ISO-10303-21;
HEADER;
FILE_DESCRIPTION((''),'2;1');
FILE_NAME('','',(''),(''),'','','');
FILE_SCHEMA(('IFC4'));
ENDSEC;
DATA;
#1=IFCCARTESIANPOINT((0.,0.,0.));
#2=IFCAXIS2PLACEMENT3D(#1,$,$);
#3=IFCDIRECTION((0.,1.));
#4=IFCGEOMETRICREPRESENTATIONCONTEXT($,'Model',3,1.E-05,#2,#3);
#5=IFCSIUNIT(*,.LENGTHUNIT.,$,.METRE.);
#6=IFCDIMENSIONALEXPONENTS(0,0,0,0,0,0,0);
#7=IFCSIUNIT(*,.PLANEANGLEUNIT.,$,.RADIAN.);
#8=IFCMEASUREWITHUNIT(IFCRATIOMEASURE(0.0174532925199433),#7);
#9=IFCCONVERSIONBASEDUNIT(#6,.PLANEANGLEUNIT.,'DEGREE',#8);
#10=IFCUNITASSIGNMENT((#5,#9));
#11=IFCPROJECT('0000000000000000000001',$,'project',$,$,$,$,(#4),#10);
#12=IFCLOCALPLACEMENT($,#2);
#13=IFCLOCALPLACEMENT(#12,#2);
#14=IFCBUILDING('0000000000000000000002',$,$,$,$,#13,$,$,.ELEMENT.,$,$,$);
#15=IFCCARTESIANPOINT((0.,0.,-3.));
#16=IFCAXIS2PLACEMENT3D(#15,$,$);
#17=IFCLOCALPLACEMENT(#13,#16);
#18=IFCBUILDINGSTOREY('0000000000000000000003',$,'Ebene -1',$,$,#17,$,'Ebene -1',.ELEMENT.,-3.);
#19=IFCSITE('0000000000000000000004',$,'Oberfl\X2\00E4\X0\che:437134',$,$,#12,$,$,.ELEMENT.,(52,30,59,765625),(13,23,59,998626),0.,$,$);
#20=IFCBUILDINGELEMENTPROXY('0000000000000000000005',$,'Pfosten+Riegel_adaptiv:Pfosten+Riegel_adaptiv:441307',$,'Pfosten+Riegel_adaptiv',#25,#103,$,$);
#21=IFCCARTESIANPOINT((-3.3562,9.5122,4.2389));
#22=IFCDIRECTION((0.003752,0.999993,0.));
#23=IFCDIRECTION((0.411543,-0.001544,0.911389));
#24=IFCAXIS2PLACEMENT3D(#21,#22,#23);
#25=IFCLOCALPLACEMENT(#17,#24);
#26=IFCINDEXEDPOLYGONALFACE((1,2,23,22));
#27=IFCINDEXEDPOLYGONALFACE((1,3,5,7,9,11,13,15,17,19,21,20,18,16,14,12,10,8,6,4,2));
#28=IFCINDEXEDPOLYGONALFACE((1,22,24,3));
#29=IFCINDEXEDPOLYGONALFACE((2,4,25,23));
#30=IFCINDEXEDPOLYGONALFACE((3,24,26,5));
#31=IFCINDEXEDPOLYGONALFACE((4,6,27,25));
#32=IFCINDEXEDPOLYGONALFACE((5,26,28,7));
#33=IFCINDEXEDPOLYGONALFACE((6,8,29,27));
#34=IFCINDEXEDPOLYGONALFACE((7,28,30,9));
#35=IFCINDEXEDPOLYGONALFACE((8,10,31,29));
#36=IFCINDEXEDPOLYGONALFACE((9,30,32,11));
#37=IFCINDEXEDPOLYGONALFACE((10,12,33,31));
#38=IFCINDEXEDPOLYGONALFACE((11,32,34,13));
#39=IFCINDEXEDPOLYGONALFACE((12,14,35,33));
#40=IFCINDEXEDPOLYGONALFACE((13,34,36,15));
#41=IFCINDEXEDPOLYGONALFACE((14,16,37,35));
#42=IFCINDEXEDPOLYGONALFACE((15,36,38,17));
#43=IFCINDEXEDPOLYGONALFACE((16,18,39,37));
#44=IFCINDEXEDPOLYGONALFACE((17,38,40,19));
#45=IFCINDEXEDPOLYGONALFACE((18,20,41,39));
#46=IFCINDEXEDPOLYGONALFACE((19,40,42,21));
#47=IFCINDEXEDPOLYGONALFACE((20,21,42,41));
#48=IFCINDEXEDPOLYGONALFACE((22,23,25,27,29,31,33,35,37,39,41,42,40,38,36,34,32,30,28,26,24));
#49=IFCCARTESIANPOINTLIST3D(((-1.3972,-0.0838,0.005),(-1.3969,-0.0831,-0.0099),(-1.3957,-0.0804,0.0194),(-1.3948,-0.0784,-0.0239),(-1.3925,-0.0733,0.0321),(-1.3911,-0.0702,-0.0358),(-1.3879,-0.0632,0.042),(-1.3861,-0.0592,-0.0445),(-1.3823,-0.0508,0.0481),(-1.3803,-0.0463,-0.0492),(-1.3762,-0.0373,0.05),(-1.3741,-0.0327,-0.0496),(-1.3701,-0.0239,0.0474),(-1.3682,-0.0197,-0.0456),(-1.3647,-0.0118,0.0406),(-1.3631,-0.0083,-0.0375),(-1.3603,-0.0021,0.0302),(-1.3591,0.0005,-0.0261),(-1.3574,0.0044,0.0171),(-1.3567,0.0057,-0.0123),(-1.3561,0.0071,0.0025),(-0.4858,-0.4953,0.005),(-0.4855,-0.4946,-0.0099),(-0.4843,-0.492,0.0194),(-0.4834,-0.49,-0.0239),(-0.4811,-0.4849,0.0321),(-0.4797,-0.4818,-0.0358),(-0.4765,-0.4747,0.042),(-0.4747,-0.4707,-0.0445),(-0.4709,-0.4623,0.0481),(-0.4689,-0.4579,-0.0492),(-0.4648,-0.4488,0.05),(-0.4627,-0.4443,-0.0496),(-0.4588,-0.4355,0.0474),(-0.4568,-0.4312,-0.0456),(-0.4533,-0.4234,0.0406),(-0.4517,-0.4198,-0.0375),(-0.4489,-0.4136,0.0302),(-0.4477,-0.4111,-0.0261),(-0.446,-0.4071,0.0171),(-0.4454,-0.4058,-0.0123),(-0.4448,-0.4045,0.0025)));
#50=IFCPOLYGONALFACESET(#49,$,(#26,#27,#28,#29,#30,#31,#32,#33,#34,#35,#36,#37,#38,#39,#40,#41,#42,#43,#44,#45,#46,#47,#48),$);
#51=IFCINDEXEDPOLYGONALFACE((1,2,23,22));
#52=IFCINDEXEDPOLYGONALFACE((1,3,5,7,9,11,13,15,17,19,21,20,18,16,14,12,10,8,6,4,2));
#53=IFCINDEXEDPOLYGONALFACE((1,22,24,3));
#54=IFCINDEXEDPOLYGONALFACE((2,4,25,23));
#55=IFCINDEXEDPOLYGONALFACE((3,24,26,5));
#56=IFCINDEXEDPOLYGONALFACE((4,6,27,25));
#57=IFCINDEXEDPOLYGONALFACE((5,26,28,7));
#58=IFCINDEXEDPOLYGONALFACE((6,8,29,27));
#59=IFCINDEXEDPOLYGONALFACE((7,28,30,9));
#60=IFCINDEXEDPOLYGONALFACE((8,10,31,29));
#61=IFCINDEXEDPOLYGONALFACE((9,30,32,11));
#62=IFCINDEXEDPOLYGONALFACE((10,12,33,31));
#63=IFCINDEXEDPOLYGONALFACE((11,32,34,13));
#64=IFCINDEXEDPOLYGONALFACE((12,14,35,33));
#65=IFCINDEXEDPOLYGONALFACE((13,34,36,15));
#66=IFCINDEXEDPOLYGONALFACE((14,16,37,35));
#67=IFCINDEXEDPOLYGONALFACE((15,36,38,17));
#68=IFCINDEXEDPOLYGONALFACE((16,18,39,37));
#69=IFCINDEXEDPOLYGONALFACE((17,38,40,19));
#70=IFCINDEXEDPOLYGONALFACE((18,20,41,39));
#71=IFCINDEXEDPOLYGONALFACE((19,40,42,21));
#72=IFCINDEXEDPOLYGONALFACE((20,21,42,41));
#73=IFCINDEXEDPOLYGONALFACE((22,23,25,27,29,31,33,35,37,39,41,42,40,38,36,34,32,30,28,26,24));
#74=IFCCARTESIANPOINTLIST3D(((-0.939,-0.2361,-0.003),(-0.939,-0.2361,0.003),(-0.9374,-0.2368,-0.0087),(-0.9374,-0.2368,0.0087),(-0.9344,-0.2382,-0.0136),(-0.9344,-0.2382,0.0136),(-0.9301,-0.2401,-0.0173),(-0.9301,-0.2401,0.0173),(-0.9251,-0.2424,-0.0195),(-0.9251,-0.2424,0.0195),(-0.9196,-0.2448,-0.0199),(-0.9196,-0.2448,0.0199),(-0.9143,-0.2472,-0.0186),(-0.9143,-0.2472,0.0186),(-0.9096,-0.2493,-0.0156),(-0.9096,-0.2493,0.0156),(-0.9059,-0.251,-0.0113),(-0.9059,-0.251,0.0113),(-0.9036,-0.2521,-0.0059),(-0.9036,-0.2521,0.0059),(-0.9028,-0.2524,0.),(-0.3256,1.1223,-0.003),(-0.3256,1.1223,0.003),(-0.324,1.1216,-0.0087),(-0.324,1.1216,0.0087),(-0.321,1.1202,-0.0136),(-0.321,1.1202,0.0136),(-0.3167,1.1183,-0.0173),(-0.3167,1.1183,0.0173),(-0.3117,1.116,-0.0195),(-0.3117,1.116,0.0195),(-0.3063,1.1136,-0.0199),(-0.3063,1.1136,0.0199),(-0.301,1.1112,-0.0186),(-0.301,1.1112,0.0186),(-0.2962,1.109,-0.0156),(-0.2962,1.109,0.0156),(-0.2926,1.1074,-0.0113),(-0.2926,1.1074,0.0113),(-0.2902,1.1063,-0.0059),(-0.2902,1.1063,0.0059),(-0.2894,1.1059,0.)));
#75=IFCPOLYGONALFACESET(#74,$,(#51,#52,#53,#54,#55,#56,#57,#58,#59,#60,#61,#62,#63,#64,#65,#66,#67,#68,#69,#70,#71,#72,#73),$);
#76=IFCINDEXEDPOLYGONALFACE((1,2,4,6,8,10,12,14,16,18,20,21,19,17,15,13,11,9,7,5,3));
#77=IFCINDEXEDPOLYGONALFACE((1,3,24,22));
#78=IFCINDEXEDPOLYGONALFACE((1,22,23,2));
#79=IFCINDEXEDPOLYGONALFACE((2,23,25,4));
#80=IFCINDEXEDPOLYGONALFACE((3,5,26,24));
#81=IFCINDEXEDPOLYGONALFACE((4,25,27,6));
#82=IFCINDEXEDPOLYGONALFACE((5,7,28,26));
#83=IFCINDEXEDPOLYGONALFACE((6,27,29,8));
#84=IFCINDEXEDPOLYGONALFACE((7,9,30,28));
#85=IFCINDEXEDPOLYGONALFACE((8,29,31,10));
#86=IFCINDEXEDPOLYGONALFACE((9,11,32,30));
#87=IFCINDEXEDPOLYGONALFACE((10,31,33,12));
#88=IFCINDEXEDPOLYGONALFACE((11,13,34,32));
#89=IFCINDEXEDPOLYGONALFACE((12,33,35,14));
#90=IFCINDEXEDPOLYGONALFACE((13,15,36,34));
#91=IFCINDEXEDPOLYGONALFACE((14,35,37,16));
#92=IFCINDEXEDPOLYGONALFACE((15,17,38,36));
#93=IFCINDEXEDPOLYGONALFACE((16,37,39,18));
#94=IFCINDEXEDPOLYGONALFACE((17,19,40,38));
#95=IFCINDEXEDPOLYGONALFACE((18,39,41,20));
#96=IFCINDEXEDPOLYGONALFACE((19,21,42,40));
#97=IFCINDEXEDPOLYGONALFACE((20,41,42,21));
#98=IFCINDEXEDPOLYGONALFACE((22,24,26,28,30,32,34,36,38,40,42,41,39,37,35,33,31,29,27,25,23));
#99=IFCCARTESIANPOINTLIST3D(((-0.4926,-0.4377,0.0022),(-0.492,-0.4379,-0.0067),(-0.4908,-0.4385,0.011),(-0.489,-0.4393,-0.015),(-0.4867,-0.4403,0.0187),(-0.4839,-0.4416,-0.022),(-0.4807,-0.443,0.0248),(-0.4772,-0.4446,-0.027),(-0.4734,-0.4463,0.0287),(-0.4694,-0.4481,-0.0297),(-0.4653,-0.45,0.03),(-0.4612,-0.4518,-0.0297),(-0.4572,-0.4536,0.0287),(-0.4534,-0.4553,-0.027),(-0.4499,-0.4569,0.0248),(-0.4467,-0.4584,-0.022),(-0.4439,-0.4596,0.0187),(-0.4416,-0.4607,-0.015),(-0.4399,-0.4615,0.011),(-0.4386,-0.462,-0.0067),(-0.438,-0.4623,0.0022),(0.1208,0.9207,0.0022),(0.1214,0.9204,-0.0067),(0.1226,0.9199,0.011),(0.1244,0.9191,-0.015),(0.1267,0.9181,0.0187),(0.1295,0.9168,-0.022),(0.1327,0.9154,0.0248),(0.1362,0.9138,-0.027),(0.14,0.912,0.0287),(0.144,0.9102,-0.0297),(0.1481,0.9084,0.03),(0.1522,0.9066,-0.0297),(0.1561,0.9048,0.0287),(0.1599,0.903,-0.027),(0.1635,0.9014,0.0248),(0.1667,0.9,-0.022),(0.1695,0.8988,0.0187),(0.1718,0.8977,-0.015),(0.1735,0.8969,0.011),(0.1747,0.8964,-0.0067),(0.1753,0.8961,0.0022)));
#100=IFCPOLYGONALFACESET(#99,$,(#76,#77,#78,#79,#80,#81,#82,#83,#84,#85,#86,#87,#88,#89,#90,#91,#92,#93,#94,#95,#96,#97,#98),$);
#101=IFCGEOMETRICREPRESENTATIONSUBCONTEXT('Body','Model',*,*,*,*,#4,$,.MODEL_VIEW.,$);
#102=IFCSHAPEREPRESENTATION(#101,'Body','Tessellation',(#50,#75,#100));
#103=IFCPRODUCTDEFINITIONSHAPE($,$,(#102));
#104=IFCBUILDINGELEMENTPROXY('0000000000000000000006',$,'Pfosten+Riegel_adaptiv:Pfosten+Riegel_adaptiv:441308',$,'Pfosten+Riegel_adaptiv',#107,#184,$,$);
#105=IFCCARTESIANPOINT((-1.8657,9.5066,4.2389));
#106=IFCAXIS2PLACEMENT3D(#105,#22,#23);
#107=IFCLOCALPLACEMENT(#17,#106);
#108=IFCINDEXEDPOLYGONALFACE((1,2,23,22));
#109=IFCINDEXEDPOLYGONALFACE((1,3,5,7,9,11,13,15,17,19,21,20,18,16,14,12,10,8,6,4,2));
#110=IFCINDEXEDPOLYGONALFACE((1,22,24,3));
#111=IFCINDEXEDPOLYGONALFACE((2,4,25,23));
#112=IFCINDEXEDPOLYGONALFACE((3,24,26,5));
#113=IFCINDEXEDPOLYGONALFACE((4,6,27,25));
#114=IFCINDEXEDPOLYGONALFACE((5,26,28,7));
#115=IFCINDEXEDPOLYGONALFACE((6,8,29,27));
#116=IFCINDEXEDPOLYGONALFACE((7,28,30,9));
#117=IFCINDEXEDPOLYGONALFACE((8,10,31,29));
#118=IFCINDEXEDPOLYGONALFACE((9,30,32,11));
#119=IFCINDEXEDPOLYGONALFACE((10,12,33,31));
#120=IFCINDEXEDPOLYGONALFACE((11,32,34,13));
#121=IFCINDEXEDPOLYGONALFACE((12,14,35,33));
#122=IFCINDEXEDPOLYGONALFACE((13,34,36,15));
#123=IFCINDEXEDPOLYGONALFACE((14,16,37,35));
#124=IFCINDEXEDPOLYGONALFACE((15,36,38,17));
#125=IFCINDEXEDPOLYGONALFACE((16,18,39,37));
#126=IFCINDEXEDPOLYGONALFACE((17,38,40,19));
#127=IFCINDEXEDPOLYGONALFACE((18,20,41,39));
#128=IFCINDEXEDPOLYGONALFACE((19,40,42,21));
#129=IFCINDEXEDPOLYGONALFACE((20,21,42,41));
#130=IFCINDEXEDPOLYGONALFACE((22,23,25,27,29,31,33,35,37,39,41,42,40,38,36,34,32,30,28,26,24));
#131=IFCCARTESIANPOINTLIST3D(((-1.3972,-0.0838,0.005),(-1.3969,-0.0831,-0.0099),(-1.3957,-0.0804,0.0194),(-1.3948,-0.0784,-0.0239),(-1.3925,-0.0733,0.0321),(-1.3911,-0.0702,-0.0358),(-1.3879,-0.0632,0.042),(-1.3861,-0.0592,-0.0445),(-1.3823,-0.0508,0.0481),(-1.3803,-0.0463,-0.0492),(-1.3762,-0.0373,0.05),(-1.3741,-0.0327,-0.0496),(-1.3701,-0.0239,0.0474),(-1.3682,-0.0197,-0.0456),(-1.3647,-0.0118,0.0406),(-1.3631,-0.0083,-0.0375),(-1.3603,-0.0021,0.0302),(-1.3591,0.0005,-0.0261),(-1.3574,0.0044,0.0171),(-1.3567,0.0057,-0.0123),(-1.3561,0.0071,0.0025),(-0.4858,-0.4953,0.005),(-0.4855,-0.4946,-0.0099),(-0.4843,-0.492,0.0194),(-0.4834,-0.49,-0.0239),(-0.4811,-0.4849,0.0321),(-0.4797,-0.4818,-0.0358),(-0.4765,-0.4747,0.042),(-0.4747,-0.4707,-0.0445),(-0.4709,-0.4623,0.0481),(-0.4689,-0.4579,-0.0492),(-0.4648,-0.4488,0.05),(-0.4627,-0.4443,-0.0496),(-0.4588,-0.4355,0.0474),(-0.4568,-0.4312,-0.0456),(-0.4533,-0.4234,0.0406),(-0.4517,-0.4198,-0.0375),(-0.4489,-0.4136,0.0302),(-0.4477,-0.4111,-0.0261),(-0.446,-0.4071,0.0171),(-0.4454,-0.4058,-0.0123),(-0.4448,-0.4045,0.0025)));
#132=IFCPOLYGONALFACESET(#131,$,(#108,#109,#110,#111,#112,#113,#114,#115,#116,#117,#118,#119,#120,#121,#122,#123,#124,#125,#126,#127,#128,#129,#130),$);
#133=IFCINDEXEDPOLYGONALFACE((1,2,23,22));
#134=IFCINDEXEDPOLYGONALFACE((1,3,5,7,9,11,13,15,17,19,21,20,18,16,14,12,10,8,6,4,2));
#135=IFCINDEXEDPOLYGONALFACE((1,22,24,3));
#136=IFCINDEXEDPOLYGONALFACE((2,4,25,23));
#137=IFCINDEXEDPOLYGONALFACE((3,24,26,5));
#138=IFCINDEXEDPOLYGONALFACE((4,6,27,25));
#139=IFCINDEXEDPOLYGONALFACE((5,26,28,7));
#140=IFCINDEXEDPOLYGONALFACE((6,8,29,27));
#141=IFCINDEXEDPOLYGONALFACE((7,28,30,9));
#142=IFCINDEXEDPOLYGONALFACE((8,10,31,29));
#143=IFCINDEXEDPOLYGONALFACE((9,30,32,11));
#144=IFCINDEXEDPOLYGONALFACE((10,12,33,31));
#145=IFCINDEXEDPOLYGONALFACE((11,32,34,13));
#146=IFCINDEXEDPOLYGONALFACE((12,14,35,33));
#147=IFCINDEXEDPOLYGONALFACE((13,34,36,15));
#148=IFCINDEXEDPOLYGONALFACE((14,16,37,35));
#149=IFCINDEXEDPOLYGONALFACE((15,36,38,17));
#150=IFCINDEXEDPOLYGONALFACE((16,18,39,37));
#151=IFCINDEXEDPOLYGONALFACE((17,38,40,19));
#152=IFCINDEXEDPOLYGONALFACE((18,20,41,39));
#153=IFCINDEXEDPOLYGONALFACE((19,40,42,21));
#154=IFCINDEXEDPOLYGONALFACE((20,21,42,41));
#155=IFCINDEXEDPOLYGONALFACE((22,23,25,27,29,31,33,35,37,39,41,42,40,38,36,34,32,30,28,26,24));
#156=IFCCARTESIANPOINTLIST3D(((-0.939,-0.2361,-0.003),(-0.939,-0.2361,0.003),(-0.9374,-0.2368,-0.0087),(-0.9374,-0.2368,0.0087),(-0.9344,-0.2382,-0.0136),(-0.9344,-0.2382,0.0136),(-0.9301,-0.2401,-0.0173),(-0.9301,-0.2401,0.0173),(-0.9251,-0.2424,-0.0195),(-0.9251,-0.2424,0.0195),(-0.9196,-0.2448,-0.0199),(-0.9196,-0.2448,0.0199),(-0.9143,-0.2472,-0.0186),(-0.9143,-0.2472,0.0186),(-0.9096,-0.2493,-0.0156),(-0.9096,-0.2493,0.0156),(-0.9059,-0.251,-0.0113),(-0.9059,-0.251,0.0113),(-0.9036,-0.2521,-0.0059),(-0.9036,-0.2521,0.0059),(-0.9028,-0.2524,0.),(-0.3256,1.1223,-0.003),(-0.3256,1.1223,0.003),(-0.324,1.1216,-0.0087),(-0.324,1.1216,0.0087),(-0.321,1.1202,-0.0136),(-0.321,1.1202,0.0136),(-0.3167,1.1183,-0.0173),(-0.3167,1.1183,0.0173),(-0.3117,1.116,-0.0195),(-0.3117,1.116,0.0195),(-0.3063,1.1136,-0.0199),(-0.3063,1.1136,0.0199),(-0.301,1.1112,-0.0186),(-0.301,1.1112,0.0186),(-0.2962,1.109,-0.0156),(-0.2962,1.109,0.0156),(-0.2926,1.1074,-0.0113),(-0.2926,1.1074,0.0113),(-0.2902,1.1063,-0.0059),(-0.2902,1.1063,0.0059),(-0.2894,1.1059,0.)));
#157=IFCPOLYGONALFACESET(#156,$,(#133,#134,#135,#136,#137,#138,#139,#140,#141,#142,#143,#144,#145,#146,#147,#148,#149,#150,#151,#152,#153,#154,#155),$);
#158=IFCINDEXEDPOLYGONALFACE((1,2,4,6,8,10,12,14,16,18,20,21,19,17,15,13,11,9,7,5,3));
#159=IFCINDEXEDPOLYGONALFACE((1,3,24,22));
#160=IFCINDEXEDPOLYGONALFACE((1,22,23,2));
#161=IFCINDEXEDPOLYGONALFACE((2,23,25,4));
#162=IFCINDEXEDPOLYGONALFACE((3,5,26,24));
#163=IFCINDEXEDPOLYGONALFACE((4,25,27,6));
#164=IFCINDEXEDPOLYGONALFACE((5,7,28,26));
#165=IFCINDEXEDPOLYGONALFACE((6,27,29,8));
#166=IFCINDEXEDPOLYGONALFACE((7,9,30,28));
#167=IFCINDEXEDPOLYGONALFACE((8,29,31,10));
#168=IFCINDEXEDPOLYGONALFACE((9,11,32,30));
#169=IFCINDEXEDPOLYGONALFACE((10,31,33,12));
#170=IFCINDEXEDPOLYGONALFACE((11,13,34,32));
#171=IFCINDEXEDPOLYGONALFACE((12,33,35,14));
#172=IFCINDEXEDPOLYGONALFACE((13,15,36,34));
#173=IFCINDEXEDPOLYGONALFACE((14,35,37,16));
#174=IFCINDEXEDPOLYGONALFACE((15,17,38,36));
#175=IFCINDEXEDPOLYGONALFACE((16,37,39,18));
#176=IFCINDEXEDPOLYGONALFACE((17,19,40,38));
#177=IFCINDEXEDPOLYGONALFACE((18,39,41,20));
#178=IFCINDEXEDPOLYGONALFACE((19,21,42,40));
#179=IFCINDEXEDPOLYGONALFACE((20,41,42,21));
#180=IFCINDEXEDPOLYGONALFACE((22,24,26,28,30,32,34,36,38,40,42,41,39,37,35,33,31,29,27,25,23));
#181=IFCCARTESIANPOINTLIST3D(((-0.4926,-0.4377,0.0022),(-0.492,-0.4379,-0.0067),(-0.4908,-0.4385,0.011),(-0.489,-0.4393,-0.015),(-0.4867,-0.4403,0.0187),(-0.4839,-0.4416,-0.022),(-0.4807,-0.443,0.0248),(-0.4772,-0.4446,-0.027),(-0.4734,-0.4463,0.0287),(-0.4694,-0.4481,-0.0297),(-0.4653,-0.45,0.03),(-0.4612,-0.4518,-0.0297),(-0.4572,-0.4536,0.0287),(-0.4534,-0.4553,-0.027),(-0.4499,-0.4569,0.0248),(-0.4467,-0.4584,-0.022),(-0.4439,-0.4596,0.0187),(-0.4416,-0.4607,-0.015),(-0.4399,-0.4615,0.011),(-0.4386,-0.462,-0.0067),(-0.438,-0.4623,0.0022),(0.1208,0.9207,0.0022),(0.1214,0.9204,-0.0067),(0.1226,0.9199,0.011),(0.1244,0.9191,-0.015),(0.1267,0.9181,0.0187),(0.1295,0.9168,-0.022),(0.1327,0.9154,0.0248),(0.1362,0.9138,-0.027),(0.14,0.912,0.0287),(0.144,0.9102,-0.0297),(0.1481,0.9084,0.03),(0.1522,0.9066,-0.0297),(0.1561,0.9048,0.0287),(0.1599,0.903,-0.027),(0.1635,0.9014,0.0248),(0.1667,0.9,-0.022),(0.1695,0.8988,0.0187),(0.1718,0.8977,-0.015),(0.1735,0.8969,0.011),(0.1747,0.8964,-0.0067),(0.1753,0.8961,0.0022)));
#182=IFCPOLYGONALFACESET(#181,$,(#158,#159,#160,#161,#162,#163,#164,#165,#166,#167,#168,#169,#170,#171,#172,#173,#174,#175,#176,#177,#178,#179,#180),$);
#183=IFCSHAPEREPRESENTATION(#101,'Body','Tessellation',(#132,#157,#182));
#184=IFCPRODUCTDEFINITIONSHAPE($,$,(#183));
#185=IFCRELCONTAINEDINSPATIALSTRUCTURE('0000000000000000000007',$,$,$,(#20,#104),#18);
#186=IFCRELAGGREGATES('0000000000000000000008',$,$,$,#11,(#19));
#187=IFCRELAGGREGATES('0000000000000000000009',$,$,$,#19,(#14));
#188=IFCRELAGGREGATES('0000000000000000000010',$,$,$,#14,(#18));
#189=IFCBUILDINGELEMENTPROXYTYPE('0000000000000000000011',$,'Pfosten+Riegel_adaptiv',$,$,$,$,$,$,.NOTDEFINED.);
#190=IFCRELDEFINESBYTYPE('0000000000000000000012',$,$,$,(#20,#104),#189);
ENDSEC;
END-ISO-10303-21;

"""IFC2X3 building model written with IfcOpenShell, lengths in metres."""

from ifc_helpers import new_model, entity, si_unit, converted_unit, direction, frame, frame_2d, origin, place, context, subcontext, project, spatial, circle, extrude, source, transform, mapped, type_object, type_shapes, element, save


model = new_model("IFC2X3")

# Units and contexts
model_context = context("Model", 3, precision=1e-05, world=origin(), true_north=direction((0.0, 1.0)))
body_context = subcontext(model_context, "Body", "Model", "MODEL_VIEW")
ifc_project = project(units=[si_unit("LENGTHUNIT", "METRE"), converted_unit("PLANEANGLEUNIT", "DEGREE", entity("IfcRatioMeasure", 0.0174532925199433), si_unit("PLANEANGLEUNIT", "RADIAN"), dimensions=[0, 0, 0, 0, 0, 0, 0])], contexts=[model_context])

# Site, building, storey
site_placement = place(None, origin())
site = spatial("IfcSite", under=ifc_project, at=site_placement, Name="Oberfläche:437134", CompositionType="ELEMENT", RefLatitude=(52, 30, 59, 765625), RefLongitude=(13, 23, 59, 998626), RefElevation=0.0)
building_placement = place(site_placement, origin())
building = spatial("IfcBuilding", under=site, at=building_placement, CompositionType="ELEMENT")
storey_placement = place(building_placement, frame((0.0, 0.0, -3.0)))
storey = spatial("IfcBuildingStorey", under=building, at=storey_placement, Name="Ebene -1", LongName="Ebene -1", CompositionType="ELEMENT", Elevation=-3.0)

# Building element proxies
building_element_proxy_type_1 = type_object("IfcBuildingElementProxyType", Name="Pfosten+Riegel_adaptiv", PredefinedType="NOTDEFINED")
shared_shape_1 = source(origin(), body_context, "Body", "SweptSolid", [
    extrude(circle(Radius=0.05, at=frame_2d((0.0, 0.0), x_axis=(1.0, 0.0))), frame((-0.4653, -0.45, 0.0), z_axis=(-0.911389, 0.411546, 0.0), x_axis=(0.16937, 0.375078, -0.911389)), (0.0, 0.0, 1.0), 1.0),
    extrude(circle(Radius=0.02, at=frame_2d((0.0, 0.0), x_axis=(1.0, 0.0))), frame((-0.921, -0.2442, 0.0), z_axis=(0.411546, 0.911389, 0.0), x_axis=(0.911389, -0.411546, 0.0)), (0.0, 0.0, 1.0), 1.4904),
    extrude(circle(Radius=0.03, at=frame_2d((0.0, 0.0), x_axis=(1.0, 0.0))), frame((-0.4653, -0.45, 0.0), z_axis=(0.411546, 0.911389, 0.0), x_axis=(0.0, 0.0, 1.0)), (0.0, 0.0, 1.0), 1.4904),
])
type_shapes(building_element_proxy_type_1, [shared_shape_1])
for number, where, z_axis, x_axis, name in (
    (1, (-3.3562, 9.5122, 4.2389), (0.003752, 0.999993, 0.0), (0.411543, -0.001544, 0.911389), "Pfosten+Riegel_adaptiv:Pfosten+Riegel_adaptiv:441307"),
    (2, (-1.8657, 9.5066, 4.2389), (0.003752, 0.999993, 0.0), (0.411543, -0.001544, 0.911389), "Pfosten+Riegel_adaptiv:Pfosten+Riegel_adaptiv:441308"),
):
    element("IfcBuildingElementProxy", number, at=place(storey_placement, frame(where, z_axis=z_axis, x_axis=x_axis)), inside=storey, type_object=building_element_proxy_type_1, Name=name, ObjectType="Pfosten+Riegel_adaptiv", context=body_context, shape_type="MappedRepresentation", body=[
        mapped(shared_shape_1, transform((0.0, 0.0, 0.0), scale=1.0)),
    ])

save(model, "model.ifc")
